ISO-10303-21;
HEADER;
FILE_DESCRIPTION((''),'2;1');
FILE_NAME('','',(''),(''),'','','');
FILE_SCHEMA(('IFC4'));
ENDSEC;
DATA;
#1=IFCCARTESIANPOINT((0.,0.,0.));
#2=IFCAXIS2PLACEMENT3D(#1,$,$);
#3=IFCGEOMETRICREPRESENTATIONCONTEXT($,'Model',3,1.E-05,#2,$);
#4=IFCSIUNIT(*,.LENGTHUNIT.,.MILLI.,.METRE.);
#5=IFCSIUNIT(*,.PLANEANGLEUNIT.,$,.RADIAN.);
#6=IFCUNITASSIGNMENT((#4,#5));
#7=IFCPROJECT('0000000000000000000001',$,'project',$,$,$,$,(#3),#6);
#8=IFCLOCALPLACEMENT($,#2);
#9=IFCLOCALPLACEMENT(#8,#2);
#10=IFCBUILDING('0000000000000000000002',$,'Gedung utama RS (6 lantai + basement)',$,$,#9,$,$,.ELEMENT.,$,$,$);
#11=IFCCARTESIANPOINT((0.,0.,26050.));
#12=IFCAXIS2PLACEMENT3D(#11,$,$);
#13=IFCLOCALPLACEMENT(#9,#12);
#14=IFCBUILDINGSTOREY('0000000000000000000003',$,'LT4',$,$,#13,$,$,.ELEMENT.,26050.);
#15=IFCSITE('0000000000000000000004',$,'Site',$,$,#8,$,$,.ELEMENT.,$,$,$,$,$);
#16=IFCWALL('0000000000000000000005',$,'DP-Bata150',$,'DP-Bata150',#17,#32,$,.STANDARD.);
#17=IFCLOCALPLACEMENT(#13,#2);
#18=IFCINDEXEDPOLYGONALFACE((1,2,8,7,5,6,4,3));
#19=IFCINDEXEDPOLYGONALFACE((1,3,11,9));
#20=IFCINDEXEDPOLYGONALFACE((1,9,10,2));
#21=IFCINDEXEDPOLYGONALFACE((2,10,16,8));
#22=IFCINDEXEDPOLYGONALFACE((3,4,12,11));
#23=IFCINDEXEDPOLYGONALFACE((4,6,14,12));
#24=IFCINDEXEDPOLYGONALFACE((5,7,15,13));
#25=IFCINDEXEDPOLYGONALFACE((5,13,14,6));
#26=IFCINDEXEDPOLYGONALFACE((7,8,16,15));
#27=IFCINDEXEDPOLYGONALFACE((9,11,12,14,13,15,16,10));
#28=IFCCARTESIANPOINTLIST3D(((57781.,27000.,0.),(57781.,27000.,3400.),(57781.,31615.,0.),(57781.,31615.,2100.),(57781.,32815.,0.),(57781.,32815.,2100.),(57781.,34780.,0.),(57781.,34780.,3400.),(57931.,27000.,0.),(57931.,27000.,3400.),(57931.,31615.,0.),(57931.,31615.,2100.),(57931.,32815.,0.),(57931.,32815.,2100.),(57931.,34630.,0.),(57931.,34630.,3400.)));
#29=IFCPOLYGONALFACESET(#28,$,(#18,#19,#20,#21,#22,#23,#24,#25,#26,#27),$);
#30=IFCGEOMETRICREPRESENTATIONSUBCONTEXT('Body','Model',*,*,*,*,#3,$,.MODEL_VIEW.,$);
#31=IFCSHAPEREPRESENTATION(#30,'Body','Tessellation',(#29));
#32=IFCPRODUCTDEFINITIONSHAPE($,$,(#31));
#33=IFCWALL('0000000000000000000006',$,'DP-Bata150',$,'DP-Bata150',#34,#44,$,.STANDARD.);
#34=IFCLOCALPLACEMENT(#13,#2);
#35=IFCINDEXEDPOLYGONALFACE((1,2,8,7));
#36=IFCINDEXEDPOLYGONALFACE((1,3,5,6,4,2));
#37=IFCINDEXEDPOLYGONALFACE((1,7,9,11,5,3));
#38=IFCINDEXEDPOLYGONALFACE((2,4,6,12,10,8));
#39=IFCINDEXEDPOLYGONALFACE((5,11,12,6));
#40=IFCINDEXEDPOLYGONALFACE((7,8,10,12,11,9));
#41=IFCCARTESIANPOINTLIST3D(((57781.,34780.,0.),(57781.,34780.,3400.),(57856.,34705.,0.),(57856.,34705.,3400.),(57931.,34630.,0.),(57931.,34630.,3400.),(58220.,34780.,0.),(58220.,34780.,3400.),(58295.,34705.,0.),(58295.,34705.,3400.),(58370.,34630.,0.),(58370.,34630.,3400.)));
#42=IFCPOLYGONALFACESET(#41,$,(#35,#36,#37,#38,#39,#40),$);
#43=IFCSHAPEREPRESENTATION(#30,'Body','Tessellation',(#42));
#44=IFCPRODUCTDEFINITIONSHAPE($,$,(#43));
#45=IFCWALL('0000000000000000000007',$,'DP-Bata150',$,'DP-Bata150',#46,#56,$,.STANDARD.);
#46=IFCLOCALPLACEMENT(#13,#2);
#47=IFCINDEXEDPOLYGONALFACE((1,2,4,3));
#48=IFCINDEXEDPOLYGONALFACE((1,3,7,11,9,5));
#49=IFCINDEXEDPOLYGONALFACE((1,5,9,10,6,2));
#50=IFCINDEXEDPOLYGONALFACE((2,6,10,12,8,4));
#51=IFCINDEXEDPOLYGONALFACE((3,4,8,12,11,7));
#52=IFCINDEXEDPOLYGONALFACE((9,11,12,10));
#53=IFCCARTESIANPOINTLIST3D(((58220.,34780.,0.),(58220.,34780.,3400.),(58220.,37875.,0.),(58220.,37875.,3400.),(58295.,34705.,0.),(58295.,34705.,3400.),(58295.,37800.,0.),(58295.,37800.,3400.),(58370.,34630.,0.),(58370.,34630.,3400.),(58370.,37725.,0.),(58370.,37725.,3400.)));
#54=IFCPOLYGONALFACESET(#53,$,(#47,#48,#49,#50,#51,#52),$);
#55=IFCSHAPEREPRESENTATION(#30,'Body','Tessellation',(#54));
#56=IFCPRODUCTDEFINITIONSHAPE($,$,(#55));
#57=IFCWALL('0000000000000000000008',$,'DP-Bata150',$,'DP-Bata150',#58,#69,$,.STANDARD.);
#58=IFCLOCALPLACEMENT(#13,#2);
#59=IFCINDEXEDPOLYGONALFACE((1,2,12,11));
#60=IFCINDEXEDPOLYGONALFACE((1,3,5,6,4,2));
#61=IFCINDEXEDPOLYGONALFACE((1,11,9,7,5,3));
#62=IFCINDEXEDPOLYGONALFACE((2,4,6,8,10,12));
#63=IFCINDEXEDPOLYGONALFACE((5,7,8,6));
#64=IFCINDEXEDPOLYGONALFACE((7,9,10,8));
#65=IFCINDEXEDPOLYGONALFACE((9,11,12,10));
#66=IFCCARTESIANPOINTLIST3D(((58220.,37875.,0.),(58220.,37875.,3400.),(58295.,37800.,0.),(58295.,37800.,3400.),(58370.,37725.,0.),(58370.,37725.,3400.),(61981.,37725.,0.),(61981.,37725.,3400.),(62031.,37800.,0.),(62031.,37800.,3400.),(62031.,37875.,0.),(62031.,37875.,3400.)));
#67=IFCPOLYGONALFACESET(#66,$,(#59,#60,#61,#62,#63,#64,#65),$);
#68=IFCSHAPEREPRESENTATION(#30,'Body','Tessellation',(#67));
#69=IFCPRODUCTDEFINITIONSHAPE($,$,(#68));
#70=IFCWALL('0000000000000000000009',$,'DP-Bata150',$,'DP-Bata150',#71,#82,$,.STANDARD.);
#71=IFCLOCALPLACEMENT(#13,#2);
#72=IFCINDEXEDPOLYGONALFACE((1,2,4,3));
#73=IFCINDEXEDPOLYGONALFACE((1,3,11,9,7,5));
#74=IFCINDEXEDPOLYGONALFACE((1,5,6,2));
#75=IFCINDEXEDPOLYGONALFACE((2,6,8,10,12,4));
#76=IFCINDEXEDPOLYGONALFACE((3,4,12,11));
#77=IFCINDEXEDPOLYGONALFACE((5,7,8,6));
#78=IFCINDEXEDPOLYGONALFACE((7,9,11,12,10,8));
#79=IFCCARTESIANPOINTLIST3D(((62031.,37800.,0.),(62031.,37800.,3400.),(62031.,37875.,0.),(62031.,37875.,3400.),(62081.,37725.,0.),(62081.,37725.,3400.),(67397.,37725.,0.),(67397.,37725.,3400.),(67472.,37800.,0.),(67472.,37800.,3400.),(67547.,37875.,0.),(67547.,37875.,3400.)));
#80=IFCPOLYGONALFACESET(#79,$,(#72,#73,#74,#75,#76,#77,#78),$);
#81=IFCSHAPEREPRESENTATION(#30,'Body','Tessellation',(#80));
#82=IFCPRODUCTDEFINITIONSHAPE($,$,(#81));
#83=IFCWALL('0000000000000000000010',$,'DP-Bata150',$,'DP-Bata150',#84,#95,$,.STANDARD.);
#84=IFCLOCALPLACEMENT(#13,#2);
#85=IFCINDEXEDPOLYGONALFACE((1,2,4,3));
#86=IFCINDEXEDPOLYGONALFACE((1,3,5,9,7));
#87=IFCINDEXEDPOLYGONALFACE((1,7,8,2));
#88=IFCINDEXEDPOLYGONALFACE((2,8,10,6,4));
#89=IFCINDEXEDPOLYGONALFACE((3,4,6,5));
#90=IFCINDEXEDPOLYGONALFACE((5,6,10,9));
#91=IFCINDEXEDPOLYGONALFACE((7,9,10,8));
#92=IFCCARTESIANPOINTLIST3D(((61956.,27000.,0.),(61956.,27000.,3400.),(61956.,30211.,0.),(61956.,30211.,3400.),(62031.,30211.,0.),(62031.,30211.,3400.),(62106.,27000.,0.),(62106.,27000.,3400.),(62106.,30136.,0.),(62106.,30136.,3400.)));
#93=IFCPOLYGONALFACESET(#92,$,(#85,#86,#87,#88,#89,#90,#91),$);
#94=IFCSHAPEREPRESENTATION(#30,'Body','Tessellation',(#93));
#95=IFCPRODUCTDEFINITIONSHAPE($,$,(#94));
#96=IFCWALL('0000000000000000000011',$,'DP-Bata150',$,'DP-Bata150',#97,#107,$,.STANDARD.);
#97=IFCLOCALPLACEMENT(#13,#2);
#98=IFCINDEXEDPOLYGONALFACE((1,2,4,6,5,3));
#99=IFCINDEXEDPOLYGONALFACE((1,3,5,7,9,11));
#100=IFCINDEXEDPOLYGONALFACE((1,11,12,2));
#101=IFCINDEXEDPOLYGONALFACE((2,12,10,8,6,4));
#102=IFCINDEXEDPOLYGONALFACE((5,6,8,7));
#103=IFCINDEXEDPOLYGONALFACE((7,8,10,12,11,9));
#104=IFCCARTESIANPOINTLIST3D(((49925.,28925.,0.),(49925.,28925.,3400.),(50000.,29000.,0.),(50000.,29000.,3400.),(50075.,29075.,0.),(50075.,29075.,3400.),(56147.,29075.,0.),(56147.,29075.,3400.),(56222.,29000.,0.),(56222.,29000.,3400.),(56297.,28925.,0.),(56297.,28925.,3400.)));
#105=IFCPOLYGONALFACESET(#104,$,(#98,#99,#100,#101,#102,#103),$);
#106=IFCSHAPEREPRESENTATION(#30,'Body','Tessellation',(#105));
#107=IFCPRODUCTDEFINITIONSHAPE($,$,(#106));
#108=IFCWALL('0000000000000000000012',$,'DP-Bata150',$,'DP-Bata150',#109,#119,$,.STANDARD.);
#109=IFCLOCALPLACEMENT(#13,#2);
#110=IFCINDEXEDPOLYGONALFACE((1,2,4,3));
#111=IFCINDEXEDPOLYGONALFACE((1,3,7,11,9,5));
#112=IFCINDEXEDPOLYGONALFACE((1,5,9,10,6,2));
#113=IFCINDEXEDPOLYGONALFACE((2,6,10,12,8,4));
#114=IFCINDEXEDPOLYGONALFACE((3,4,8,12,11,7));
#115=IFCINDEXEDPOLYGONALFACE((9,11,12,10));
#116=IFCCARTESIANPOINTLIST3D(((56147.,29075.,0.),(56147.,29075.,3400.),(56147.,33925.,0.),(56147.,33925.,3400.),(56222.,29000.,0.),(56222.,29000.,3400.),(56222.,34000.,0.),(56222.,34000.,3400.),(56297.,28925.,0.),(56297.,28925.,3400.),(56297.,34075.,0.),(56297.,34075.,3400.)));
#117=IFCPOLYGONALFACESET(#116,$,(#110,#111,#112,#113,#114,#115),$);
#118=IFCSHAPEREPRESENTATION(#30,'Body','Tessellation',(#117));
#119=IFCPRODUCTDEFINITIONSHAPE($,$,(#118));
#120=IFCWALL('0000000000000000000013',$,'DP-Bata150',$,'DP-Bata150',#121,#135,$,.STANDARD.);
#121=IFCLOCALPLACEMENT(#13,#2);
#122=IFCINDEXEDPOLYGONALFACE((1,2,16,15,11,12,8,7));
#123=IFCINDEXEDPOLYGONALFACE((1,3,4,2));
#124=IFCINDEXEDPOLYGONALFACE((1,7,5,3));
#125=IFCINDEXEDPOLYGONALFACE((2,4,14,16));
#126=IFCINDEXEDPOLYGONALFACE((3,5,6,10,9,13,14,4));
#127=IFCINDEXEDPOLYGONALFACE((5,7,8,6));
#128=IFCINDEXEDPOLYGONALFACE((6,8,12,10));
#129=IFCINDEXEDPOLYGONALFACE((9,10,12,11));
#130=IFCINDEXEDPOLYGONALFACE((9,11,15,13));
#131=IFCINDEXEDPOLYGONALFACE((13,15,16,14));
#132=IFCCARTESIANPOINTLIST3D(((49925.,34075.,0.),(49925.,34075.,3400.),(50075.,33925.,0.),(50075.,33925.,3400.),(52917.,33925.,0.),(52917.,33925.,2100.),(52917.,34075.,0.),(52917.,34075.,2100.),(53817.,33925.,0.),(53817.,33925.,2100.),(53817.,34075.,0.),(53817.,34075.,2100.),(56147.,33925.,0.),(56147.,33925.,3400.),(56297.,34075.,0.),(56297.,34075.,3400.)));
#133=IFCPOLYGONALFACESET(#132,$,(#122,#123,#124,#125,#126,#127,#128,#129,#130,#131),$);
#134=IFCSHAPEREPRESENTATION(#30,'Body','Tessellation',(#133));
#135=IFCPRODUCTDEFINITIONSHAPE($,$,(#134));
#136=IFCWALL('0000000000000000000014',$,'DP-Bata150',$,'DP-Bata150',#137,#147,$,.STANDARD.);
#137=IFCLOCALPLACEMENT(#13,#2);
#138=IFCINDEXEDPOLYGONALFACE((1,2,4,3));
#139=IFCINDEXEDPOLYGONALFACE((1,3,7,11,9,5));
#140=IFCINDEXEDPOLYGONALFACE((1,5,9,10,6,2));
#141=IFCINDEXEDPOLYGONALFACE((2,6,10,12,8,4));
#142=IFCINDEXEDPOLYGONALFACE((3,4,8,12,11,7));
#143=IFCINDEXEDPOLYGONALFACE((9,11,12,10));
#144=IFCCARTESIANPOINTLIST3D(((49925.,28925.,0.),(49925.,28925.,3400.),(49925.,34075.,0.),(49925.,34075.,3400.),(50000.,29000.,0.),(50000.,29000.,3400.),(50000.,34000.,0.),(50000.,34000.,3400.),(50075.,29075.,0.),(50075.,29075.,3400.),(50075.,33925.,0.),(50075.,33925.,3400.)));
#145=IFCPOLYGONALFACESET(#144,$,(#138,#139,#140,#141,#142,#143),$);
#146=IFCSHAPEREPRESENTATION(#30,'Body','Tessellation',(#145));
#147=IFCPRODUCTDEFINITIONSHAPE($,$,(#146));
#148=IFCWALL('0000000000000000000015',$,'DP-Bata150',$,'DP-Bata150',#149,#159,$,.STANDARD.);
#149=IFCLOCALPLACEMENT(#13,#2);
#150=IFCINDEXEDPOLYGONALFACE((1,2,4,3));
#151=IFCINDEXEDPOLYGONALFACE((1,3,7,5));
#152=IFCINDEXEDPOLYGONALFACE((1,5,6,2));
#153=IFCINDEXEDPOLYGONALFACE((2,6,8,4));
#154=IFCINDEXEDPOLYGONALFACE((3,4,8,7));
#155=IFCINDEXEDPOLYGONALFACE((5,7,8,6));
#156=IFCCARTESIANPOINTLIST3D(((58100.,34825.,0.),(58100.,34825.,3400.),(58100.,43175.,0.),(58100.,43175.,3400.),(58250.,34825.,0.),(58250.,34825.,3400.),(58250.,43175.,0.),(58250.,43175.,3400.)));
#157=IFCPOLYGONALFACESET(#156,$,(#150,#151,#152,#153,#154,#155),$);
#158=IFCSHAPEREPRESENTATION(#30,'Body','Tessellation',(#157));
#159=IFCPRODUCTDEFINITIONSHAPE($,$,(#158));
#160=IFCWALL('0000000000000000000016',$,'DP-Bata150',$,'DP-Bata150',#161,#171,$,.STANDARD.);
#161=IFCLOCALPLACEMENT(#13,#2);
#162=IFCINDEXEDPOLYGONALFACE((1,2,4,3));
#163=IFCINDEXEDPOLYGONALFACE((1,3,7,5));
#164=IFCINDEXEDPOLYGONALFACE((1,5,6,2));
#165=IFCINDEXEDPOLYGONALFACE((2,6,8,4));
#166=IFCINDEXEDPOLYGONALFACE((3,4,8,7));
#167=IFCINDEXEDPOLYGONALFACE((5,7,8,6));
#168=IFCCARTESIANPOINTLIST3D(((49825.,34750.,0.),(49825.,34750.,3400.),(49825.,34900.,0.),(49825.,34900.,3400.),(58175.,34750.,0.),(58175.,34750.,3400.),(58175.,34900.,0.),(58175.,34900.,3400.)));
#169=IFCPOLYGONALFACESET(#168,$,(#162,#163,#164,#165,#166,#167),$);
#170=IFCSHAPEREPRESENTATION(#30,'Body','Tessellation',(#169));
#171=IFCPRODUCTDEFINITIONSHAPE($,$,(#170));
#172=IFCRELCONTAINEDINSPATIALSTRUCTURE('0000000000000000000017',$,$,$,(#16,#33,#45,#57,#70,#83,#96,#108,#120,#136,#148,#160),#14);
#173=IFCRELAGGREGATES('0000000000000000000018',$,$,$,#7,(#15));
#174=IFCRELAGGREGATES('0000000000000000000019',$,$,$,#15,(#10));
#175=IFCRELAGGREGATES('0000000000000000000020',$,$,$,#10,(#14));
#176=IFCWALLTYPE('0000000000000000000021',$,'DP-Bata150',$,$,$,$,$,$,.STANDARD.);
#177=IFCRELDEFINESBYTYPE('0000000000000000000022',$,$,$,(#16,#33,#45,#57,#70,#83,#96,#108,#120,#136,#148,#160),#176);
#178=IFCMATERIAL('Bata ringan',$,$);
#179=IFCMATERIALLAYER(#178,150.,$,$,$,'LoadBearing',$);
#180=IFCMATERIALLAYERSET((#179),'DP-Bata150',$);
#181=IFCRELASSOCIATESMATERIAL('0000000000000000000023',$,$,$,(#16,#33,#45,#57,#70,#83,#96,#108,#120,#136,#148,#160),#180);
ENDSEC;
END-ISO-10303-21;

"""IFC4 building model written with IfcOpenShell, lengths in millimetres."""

from ifc_helpers import new_model, si_unit, frame, frame_2d, origin, place, context, subcontext, project, spatial, polyline, rectangle, outline, extrude, material, layer, layer_set, layer_usage, type_object, element, save


model = new_model("IFC4")

# Units and contexts
model_context = context("Model", 3, precision=1e-05, world=origin())
body_context = subcontext(model_context, "Body", "Model", "MODEL_VIEW")
ifc_project = project(units=[si_unit("LENGTHUNIT", "METRE", prefix="MILLI"), si_unit("PLANEANGLEUNIT", "RADIAN")], contexts=[model_context])

# Site, building, storey
site_placement = place(None, origin())
site = spatial("IfcSite", under=ifc_project, at=site_placement, Name="Site", CompositionType="ELEMENT")
building_placement = place(site_placement, origin())
building = spatial("IfcBuilding", under=site, at=building_placement, Name="Gedung utama RS (6 lantai + basement)", CompositionType="ELEMENT")
storey_placement = place(building_placement, frame((0.0, 0.0, 26050.0)))
storey = spatial("IfcBuildingStorey", under=building, at=storey_placement, Name="LT4", CompositionType="ELEMENT", Elevation=26050.0)

# Shared definitions
ifc_material_1 = material(Name="Bata ringan")

# Wall, opening
ifc_layer_1 = layer(ifc_material_1, 150.0, Category="LoadBearing")
ifc_layer_set_1 = layer_set([ifc_layer_1], Name="DP-Bata150")
ifc_layer_usage_1 = layer_usage(ifc_layer_set_1, "AXIS2", "NEGATIVE", 75.0)
wall_type_1 = type_object("IfcWallType", Name="DP-Bata150", PredefinedType="STANDARD")
wall_1_placement = place(storey_placement, frame((57856.0, 27000.0, 0.0), z_axis=(0.0, 0.0, 1.0), x_axis=(0.0, 1.0, 0.0)))
wall_1 = element("IfcWall", 1, at=wall_1_placement, inside=storey, type_object=wall_type_1, material=ifc_layer_usage_1, Name="DP-Bata150", ObjectType="DP-Bata150", PredefinedType="STANDARD", context=body_context, shape_type="SweptSolid", body=[
    extrude(outline(polyline([(0.0, -75.0), (0.0, 75.0), (7780.0, 75.0), (7705.0, 0.0), (7630.0, -75.0), (0.0, -75.0)])), origin(), (0.0, 0.0, 1.0), 3400.0),
])
opening_1_placement = place(wall_1_placement, frame((4615.0, 0.0, 0.0), z_axis=(0.0, 0.0, 1.0), x_axis=(1.0, 0.0, 0.0)))
element("IfcOpeningElement", 2, at=opening_1_placement, cuts=wall_1, PredefinedType="OPENING", context=body_context, shape_type="SweptSolid", body=[
    extrude(rectangle(XDim=1200.0, YDim=170.0, at=frame_2d((600.0, 0.0))), origin(), (0.0, 0.0, 1.0), 2100.0),
])

# Walls
wall_2_placement = place(storey_placement, frame((57856.0, 34705.0, 0.0), z_axis=(0.0, 0.0, 1.0), x_axis=(1.0, 0.0, 0.0)))
element("IfcWall", 3, at=wall_2_placement, inside=storey, type_object=wall_type_1, material=ifc_layer_usage_1, Name="DP-Bata150", ObjectType="DP-Bata150", PredefinedType="STANDARD", context=body_context, shape_type="SweptSolid", body=[
    extrude(outline(polyline([(75.0, -75.0), (0.0, 0.0), (-75.0, 75.0), (364.0, 75.0), (439.0, 0.0), (514.0, -75.0), (75.0, -75.0)])), origin(), (0.0, 0.0, 1.0), 3400.0),
])
wall_3_placement = place(storey_placement, frame((58295.0, 34705.0, 0.0), z_axis=(0.0, 0.0, 1.0), x_axis=(0.0, 1.0, 0.0)))
element("IfcWall", 4, at=wall_3_placement, inside=storey, type_object=wall_type_1, material=ifc_layer_usage_1, Name="DP-Bata150", ObjectType="DP-Bata150", PredefinedType="STANDARD", context=body_context, shape_type="SweptSolid", body=[
    extrude(outline(polyline([(-75.0, -75.0), (0.0, 0.0), (75.0, 75.0), (3170.0, 75.0), (3095.0, 0.0), (3020.0, -75.0), (-75.0, -75.0)])), origin(), (0.0, 0.0, 1.0), 3400.0),
])
wall_4_placement = place(storey_placement, frame((58295.0, 37800.0, 0.0), z_axis=(0.0, 0.0, 1.0), x_axis=(1.0, 0.0, 0.0)))
element("IfcWall", 5, at=wall_4_placement, inside=storey, type_object=wall_type_1, material=ifc_layer_usage_1, Name="DP-Bata150", ObjectType="DP-Bata150", PredefinedType="STANDARD", context=body_context, shape_type="SweptSolid", body=[
    extrude(outline(polyline([(75.0, -75.0), (0.0, 0.0), (-75.0, 75.0), (3736.0, 75.0), (3736.0, 0.0), (3686.0, -75.0), (75.0, -75.0)])), origin(), (0.0, 0.0, 1.0), 3400.0),
])
wall_5_placement = place(storey_placement, frame((62031.0, 37800.0, 0.0), z_axis=(0.0, 0.0, 1.0), x_axis=(1.0, 0.0, 0.0)))
element("IfcWall", 6, at=wall_5_placement, inside=storey, type_object=wall_type_1, material=ifc_layer_usage_1, Name="DP-Bata150", ObjectType="DP-Bata150", PredefinedType="STANDARD", context=body_context, shape_type="SweptSolid", body=[
    extrude(outline(polyline([(50.0, -75.0), (0.0, 0.0), (0.0, 75.0), (5516.0, 75.0), (5441.0, 0.0), (5366.0, -75.0), (50.0, -75.0)])), origin(), (0.0, 0.0, 1.0), 3400.0),
])
wall_6_placement = place(storey_placement, frame((62031.0, 30211.0, 0.0), z_axis=(0.0, 0.0, 1.0), x_axis=(0.0, -1.0, 0.0)))
element("IfcWall", 7, at=wall_6_placement, inside=storey, type_object=wall_type_1, material=ifc_layer_usage_1, Name="DP-Bata150", ObjectType="DP-Bata150", PredefinedType="STANDARD", context=body_context, shape_type="SweptSolid", body=[
    extrude(outline(polyline([(0.0, -75.0), (0.0, 0.0), (75.0, 75.0), (3211.0, 75.0), (3211.0, -75.0), (0.0, -75.0)])), origin(), (0.0, 0.0, 1.0), 3400.0),
])
wall_7_placement = place(storey_placement, frame((50000.0, 29000.0, 0.0), z_axis=(0.0, 0.0, 1.0), x_axis=(1.0, 0.0, 0.0)))
element("IfcWall", 8, at=wall_7_placement, inside=storey, type_object=wall_type_1, material=ifc_layer_usage_1, Name="DP-Bata150", ObjectType="DP-Bata150", PredefinedType="STANDARD", context=body_context, shape_type="SweptSolid", body=[
    extrude(outline(polyline([(-75.0, -75.0), (0.0, 0.0), (75.0, 75.0), (6147.0, 75.0), (6222.0, 0.0), (6297.0, -75.0), (-75.0, -75.0)])), origin(), (0.0, 0.0, 1.0), 3400.0),
])
wall_8_placement = place(storey_placement, frame((56222.0, 29000.0, 0.0), z_axis=(0.0, 0.0, 1.0), x_axis=(0.0, 1.0, 0.0)))
element("IfcWall", 9, at=wall_8_placement, inside=storey, type_object=wall_type_1, material=ifc_layer_usage_1, Name="DP-Bata150", ObjectType="DP-Bata150", PredefinedType="STANDARD", context=body_context, shape_type="SweptSolid", body=[
    extrude(outline(polyline([(-75.0, -75.0), (0.0, 0.0), (75.0, 75.0), (4925.0, 75.0), (5000.0, 0.0), (5075.0, -75.0), (-75.0, -75.0)])), origin(), (0.0, 0.0, 1.0), 3400.0),
])

# Wall, opening
wall_9_placement = place(storey_placement, frame((56222.0, 34000.0, 0.0), z_axis=(0.0, 0.0, 1.0), x_axis=(-1.0, 0.0, 0.0)))
wall_9 = element("IfcWall", 10, at=wall_9_placement, inside=storey, type_object=wall_type_1, material=ifc_layer_usage_1, Name="DP-Bata150", ObjectType="DP-Bata150", PredefinedType="STANDARD", context=body_context, shape_type="SweptSolid", body=[
    extrude(outline(polyline([(-75.0, -75.0), (0.0, 0.0), (75.0, 75.0), (6147.0, 75.0), (6222.0, 0.0), (6297.0, -75.0), (-75.0, -75.0)])), origin(), (0.0, 0.0, 1.0), 3400.0),
])
opening_2_placement = place(wall_9_placement, frame((2405.0, 0.0, 0.0), z_axis=(0.0, 0.0, 1.0), x_axis=(1.0, 0.0, 0.0)))
element("IfcOpeningElement", 11, at=opening_2_placement, cuts=wall_9, PredefinedType="OPENING", context=body_context, shape_type="SweptSolid", body=[
    extrude(rectangle(XDim=900.0, YDim=170.0, at=frame_2d((450.0, 0.0))), origin(), (0.0, 0.0, 1.0), 2100.0),
])

# Walls
wall_10_placement = place(storey_placement, frame((50000.0, 34000.0, 0.0), z_axis=(0.0, 0.0, 1.0), x_axis=(0.0, -1.0, 0.0)))
element("IfcWall", 12, at=wall_10_placement, inside=storey, type_object=wall_type_1, material=ifc_layer_usage_1, Name="DP-Bata150", ObjectType="DP-Bata150", PredefinedType="STANDARD", context=body_context, shape_type="SweptSolid", body=[
    extrude(outline(polyline([(-75.0, -75.0), (0.0, 0.0), (75.0, 75.0), (4925.0, 75.0), (5000.0, 0.0), (5075.0, -75.0), (-75.0, -75.0)])), origin(), (0.0, 0.0, 1.0), 3400.0),
])
for number, where, z_axis, x_axis, name in (
    (13, (58175.0, 34825.0, 0.0), (0.0, 0.0, 1.0), (0.0, 1.0, 0.0), "DP-Bata150"),
    (14, (49825.0, 34825.0, 0.0), (0.0, 0.0, 1.0), (1.0, 0.0, 0.0), "DP-Bata150"),
):
    element("IfcWall", number, at=place(storey_placement, frame(where, z_axis=z_axis, x_axis=x_axis)), inside=storey, type_object=wall_type_1, material=ifc_layer_usage_1, Name=name, ObjectType="DP-Bata150", PredefinedType="STANDARD", context=body_context, shape_type="SweptSolid", body=[
        extrude(outline(polyline([(0.0, -75.0), (0.0, 75.0), (8350.0, 75.0), (8350.0, -75.0), (0.0, -75.0)])), origin(), (0.0, 0.0, 1.0), 3400.0),
    ])

save(model, "model.ifc")
